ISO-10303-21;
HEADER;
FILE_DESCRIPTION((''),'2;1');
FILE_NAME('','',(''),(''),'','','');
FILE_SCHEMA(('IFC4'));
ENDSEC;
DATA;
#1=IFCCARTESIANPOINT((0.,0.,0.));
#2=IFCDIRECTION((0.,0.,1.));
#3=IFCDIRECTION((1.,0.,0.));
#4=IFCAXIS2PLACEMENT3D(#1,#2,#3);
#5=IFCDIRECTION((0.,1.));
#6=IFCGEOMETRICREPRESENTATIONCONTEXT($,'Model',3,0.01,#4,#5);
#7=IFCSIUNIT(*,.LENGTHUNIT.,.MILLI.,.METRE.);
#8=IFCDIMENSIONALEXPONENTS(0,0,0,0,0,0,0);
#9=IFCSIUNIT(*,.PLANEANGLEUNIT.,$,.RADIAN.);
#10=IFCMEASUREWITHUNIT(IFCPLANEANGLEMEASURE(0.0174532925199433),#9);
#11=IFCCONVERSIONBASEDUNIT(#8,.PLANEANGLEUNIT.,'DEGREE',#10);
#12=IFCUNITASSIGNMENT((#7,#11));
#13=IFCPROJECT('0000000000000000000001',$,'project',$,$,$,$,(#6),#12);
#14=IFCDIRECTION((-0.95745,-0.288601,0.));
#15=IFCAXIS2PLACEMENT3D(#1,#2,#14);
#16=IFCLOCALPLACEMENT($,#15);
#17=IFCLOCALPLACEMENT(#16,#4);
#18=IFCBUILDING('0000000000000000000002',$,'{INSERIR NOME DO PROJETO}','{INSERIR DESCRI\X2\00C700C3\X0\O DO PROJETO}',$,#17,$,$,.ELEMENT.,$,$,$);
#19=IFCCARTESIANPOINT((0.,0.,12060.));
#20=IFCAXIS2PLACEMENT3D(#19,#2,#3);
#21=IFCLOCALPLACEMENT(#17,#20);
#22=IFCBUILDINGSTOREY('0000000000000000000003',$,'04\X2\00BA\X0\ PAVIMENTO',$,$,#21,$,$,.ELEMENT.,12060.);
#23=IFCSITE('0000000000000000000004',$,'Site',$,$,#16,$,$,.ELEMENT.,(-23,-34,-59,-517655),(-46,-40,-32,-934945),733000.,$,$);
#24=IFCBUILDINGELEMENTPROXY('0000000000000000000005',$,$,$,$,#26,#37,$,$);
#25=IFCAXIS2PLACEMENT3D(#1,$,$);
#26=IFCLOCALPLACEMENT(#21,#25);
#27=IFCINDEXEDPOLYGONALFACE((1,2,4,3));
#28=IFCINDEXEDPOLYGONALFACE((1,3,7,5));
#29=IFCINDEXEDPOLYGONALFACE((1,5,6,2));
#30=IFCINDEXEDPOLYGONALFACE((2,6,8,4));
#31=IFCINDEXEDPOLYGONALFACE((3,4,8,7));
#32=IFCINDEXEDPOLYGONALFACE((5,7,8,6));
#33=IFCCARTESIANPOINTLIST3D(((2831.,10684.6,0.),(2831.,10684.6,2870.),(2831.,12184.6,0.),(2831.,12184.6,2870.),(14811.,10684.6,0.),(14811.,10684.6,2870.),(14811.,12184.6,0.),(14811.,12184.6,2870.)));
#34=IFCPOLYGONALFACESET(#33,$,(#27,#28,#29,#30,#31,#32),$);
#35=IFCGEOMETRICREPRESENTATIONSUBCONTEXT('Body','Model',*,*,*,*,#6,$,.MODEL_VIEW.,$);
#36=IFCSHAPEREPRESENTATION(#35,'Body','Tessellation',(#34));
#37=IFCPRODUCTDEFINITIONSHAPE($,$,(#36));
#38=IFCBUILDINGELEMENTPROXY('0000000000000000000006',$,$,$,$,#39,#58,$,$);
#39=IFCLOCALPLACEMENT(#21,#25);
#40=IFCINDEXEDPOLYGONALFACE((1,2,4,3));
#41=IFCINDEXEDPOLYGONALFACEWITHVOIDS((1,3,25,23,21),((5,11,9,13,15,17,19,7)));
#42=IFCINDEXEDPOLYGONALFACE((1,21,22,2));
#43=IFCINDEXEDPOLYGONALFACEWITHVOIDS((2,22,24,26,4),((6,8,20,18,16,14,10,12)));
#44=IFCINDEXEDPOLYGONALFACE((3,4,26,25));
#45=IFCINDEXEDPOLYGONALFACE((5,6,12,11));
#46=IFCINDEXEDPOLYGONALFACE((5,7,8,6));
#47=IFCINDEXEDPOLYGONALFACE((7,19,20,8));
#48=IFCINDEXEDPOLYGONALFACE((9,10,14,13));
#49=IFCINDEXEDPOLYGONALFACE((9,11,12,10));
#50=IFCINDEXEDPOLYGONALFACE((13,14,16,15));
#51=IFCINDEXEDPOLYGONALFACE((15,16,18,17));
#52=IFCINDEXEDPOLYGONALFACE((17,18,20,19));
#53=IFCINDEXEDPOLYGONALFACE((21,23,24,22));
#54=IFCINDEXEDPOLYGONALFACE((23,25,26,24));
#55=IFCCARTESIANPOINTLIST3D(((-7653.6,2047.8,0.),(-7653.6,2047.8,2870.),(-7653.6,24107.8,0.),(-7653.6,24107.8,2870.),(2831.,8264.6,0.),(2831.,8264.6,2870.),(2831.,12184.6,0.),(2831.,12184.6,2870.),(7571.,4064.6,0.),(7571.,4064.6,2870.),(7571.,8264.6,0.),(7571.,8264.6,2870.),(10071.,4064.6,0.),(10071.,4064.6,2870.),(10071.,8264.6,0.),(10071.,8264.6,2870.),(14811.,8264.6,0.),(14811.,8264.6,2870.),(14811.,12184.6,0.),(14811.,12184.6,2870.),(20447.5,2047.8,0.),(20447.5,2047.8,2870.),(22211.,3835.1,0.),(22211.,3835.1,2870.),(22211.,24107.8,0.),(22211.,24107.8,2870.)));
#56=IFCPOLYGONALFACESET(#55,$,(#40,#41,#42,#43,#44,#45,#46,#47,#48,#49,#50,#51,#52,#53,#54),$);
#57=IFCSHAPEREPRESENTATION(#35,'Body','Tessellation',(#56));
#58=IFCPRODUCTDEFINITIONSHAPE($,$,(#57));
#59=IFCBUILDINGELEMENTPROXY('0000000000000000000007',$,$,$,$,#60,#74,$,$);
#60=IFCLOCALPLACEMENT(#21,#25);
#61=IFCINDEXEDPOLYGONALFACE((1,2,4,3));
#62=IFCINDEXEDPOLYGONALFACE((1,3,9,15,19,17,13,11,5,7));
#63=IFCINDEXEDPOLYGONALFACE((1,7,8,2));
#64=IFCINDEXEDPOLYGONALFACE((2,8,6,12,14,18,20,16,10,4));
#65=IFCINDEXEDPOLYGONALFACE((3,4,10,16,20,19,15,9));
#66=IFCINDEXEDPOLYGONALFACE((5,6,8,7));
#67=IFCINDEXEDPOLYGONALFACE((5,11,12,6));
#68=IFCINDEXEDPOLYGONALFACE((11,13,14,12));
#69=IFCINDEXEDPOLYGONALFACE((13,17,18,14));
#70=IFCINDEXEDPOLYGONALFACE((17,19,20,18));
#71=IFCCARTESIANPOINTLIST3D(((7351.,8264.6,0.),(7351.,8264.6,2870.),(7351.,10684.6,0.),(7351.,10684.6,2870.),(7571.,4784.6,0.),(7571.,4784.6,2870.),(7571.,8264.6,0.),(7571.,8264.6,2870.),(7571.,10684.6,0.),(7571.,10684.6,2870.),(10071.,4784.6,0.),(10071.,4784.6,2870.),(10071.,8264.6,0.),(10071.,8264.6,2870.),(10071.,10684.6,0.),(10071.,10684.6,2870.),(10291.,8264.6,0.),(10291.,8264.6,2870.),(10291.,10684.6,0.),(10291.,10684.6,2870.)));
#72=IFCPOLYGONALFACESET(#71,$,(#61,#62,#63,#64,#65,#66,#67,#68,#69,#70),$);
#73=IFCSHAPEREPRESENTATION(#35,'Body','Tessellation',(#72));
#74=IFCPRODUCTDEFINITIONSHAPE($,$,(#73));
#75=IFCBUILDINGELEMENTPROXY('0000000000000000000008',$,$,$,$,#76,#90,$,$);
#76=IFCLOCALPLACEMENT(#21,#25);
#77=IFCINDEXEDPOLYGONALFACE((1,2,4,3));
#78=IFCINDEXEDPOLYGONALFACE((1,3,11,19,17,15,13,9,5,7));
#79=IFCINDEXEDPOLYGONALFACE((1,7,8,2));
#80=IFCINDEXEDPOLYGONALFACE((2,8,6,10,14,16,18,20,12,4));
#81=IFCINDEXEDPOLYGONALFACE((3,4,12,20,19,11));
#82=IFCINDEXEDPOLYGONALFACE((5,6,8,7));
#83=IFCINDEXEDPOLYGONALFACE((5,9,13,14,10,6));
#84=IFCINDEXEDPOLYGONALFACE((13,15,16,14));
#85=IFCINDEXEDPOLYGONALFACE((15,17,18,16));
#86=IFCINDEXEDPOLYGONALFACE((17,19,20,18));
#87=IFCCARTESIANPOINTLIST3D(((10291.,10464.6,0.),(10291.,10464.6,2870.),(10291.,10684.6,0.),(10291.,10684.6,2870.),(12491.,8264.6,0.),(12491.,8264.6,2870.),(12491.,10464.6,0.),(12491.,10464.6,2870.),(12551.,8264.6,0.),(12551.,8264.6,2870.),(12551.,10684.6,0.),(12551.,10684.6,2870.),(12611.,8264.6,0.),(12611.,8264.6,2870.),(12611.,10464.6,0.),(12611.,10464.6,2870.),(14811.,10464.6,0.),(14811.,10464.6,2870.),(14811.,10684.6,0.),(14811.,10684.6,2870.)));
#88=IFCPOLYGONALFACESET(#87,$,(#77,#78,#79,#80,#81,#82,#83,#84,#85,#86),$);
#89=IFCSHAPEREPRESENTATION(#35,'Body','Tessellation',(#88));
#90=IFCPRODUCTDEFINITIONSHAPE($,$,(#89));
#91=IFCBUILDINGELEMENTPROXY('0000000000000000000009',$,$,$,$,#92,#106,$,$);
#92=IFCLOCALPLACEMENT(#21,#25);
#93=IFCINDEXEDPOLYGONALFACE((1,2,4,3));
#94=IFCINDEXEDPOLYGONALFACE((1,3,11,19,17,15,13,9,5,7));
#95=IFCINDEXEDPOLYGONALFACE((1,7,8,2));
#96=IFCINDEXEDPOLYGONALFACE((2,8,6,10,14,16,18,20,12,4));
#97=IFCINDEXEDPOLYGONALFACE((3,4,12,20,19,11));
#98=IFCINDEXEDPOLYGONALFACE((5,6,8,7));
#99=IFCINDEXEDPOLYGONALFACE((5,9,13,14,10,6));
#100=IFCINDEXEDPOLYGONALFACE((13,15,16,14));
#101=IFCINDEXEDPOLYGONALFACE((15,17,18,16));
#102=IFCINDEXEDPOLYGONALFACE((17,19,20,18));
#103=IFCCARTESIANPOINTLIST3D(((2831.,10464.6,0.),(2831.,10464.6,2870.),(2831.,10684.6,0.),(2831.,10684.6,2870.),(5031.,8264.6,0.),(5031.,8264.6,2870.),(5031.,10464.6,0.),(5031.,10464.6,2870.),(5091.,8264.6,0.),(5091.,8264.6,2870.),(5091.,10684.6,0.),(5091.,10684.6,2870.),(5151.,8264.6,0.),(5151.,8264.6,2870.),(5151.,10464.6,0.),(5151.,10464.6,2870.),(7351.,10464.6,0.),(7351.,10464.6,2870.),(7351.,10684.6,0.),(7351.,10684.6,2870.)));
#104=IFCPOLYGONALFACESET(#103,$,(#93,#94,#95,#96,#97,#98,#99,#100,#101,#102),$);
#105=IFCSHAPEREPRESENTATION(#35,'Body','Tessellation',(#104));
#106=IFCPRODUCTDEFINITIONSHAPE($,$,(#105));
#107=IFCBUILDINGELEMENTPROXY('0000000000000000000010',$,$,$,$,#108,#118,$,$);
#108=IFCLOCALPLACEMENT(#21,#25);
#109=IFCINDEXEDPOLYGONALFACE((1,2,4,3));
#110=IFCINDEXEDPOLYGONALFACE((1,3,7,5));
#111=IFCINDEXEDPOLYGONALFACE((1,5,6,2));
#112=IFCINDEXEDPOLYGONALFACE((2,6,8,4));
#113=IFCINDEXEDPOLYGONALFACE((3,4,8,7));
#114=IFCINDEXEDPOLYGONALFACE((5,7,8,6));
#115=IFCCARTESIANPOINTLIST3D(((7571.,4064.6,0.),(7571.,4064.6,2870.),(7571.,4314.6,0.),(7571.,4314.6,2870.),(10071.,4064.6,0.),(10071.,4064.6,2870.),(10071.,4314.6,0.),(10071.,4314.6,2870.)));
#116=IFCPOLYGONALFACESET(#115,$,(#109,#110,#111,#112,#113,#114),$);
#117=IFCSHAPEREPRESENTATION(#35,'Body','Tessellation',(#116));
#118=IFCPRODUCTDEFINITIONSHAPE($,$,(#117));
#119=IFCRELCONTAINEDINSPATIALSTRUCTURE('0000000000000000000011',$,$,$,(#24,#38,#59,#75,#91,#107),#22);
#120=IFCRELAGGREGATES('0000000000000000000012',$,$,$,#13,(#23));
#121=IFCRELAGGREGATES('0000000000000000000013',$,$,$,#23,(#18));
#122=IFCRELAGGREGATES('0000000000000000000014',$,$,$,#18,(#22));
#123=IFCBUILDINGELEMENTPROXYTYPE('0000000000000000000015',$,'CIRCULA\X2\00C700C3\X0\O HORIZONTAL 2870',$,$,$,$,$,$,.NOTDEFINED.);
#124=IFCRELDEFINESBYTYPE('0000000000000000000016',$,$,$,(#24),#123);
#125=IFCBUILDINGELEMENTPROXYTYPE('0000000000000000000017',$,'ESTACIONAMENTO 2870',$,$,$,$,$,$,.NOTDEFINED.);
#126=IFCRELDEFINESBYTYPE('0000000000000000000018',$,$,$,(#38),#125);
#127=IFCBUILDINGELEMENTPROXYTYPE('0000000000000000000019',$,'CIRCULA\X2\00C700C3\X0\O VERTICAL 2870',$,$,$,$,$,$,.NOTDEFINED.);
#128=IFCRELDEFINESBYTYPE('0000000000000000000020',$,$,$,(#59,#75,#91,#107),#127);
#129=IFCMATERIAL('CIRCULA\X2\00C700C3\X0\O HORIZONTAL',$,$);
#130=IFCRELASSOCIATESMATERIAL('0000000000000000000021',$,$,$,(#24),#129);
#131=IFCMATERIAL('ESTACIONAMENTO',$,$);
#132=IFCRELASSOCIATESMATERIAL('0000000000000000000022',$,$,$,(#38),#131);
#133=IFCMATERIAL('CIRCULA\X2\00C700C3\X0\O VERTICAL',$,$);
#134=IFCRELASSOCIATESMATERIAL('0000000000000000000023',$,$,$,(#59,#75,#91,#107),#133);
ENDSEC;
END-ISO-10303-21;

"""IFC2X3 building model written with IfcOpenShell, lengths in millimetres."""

from ifc_helpers import new_model, entity, si_unit, converted_unit, direction, frame, origin_with_axes, place, context, subcontext, project, spatial, polyline, outline, extrude, material, type_object, element, save


model = new_model("IFC2X3")

# Units and contexts
model_context = context("Model", 3, precision=0.01, world=origin_with_axes(), true_north=direction((0.0, 1.0)))
body_context = subcontext(model_context, "Body", "Model", "MODEL_VIEW")
ifc_project = project(units=[si_unit("LENGTHUNIT", "METRE", prefix="MILLI"), converted_unit("PLANEANGLEUNIT", "DEGREE", entity("IfcPlaneAngleMeasure", 0.0174532925199433), si_unit("PLANEANGLEUNIT", "RADIAN"), dimensions=[0, 0, 0, 0, 0, 0, 0])], contexts=[model_context])

# Site, building, storey
site_placement = place(None, frame((0.0, 0.0, 0.0), z_axis=(0.0, 0.0, 1.0), x_axis=(-0.95745, -0.288601, 0.0)))
site = spatial("IfcSite", under=ifc_project, at=site_placement, Name="Site", CompositionType="ELEMENT", RefLatitude=(-23, -34, -59, -517655), RefLongitude=(-46, -40, -32, -934945), RefElevation=733000.0)
building_placement = place(site_placement, origin_with_axes())
building = spatial("IfcBuilding", under=site, at=building_placement, Name="{INSERIR NOME DO PROJETO}", Description="{INSERIR DESCRIÇÃO DO PROJETO}", CompositionType="ELEMENT")
storey_placement = place(building_placement, frame((0.0, 0.0, 12060.0), z_axis=(0.0, 0.0, 1.0), x_axis=(1.0, 0.0, 0.0)))
storey = spatial("IfcBuildingStorey", under=building, at=storey_placement, Name="04º PAVIMENTO", CompositionType="ELEMENT", Elevation=12060.0)

# Building element proxies
ifc_material_1 = material(Name="CIRCULAÇÃO HORIZONTAL")
building_element_proxy_type_1 = type_object("IfcBuildingElementProxyType", Name="CIRCULAÇÃO HORIZONTAL 2870", PredefinedType="NOTDEFINED")
proxy_1_placement = place(storey_placement, frame((2831.0, 10684.6, 0.0), z_axis=(0.0, 0.0, 1.0), x_axis=(1.0, 0.0, 0.0)))
element("IfcBuildingElementProxy", 1, at=proxy_1_placement, inside=storey, type_object=building_element_proxy_type_1, material=ifc_material_1, context=body_context, shape_type="SweptSolid", body=[
    extrude(outline(polyline([(0.0, 0.0), (11980.0, 0.0), (11980.0, 1500.0), (0.0, 1500.0), (0.0, 0.0)])), origin_with_axes(), (0.0, 0.0, 1.0), 2870.0),
])
ifc_material_2 = material(Name="ESTACIONAMENTO")
building_element_proxy_type_2 = type_object("IfcBuildingElementProxyType", Name="ESTACIONAMENTO 2870", PredefinedType="NOTDEFINED")
proxy_2_placement = place(storey_placement, frame((-7653.6, 2047.8, 0.0), z_axis=(0.0, 0.0, 1.0), x_axis=(1.0, 0.0, 0.0)))
element("IfcBuildingElementProxy", 2, at=proxy_2_placement, inside=storey, type_object=building_element_proxy_type_2, material=ifc_material_2, context=body_context, shape_type="SweptSolid", body=[
    extrude(outline(polyline([(0.0, 0.0), (28101.1, 0.0), (29864.6, 1787.4), (29864.6, 22060.0), (0.0, 22060.0), (0.0, 0.0)]), holes=[polyline([(10484.6, 6216.8), (10484.6, 10136.8), (22464.6, 10136.8), (22464.6, 6216.8), (17724.6, 6216.8), (17724.6, 2016.8), (15224.6, 2016.8), (15224.6, 6216.8), (10484.6, 6216.8)])]), origin_with_axes(), (0.0, 0.0, 1.0), 2870.0),
])
ifc_material_3 = material(Name="CIRCULAÇÃO VERTICAL")
building_element_proxy_type_3 = type_object("IfcBuildingElementProxyType", Name="CIRCULAÇÃO VERTICAL 2870", PredefinedType="NOTDEFINED")
proxy_3_placement = place(storey_placement, frame((7351.0, 10684.6, 0.0), z_axis=(0.0, 0.0, 1.0), x_axis=(1.0, 0.0, 0.0)))
element("IfcBuildingElementProxy", 3, at=proxy_3_placement, inside=storey, type_object=building_element_proxy_type_3, material=ifc_material_3, context=body_context, shape_type="SweptSolid", body=[
    extrude(outline(polyline([(0.0, 0.0), (0.0, -2420.0), (220.0, -2420.0), (220.0, -5900.0), (2720.0, -5900.0), (2720.0, -2420.0), (2940.0, -2420.0), (2940.0, 0.0), (2720.0, 0.0), (220.0, 0.0), (0.0, 0.0)])), origin_with_axes(), (0.0, 0.0, 1.0), 2870.0),
])
proxy_4_placement = place(storey_placement, frame((10291.0, 10684.6, 0.0), z_axis=(0.0, 0.0, 1.0), x_axis=(1.0, 0.0, 0.0)))
element("IfcBuildingElementProxy", 4, at=proxy_4_placement, inside=storey, type_object=building_element_proxy_type_3, material=ifc_material_3, context=body_context, shape_type="SweptSolid", body=[
    extrude(outline(polyline([(0.0, 0.0), (0.0, -220.0), (2200.0, -220.0), (2200.0, -2420.0), (2260.0, -2420.0), (2320.0, -2420.0), (2320.0, -220.0), (4520.0, -220.0), (4520.0, 0.0), (2260.0, 0.0), (0.0, 0.0)])), origin_with_axes(), (0.0, 0.0, 1.0), 2870.0),
])
proxy_5_placement = place(storey_placement, frame((5091.0, 10684.6, 0.0), z_axis=(0.0, 0.0, 1.0), x_axis=(1.0, 0.0, 0.0)))
element("IfcBuildingElementProxy", 5, at=proxy_5_placement, inside=storey, type_object=building_element_proxy_type_3, material=ifc_material_3, context=body_context, shape_type="SweptSolid", body=[
    extrude(outline(polyline([(0.0, 0.0), (-2260.0, 0.0), (-2260.0, -220.0), (-60.0, -220.0), (-60.0, -2420.0), (0.0, -2420.0), (60.0, -2420.0), (60.0, -220.0), (2260.0, -220.0), (2260.0, 0.0), (0.0, 0.0)])), origin_with_axes(), (0.0, 0.0, 1.0), 2870.0),
])
proxy_6_placement = place(storey_placement, frame((7571.0, 4064.6, 0.0), z_axis=(0.0, 0.0, 1.0), x_axis=(1.0, 0.0, 0.0)))
element("IfcBuildingElementProxy", 6, at=proxy_6_placement, inside=storey, type_object=building_element_proxy_type_3, material=ifc_material_3, context=body_context, shape_type="SweptSolid", body=[
    extrude(outline(polyline([(0.0, 0.0), (2500.0, 0.0), (2500.0, 250.0), (0.0, 250.0), (0.0, 0.0)])), origin_with_axes(), (0.0, 0.0, 1.0), 2870.0),
])

save(model, "model.ifc")
